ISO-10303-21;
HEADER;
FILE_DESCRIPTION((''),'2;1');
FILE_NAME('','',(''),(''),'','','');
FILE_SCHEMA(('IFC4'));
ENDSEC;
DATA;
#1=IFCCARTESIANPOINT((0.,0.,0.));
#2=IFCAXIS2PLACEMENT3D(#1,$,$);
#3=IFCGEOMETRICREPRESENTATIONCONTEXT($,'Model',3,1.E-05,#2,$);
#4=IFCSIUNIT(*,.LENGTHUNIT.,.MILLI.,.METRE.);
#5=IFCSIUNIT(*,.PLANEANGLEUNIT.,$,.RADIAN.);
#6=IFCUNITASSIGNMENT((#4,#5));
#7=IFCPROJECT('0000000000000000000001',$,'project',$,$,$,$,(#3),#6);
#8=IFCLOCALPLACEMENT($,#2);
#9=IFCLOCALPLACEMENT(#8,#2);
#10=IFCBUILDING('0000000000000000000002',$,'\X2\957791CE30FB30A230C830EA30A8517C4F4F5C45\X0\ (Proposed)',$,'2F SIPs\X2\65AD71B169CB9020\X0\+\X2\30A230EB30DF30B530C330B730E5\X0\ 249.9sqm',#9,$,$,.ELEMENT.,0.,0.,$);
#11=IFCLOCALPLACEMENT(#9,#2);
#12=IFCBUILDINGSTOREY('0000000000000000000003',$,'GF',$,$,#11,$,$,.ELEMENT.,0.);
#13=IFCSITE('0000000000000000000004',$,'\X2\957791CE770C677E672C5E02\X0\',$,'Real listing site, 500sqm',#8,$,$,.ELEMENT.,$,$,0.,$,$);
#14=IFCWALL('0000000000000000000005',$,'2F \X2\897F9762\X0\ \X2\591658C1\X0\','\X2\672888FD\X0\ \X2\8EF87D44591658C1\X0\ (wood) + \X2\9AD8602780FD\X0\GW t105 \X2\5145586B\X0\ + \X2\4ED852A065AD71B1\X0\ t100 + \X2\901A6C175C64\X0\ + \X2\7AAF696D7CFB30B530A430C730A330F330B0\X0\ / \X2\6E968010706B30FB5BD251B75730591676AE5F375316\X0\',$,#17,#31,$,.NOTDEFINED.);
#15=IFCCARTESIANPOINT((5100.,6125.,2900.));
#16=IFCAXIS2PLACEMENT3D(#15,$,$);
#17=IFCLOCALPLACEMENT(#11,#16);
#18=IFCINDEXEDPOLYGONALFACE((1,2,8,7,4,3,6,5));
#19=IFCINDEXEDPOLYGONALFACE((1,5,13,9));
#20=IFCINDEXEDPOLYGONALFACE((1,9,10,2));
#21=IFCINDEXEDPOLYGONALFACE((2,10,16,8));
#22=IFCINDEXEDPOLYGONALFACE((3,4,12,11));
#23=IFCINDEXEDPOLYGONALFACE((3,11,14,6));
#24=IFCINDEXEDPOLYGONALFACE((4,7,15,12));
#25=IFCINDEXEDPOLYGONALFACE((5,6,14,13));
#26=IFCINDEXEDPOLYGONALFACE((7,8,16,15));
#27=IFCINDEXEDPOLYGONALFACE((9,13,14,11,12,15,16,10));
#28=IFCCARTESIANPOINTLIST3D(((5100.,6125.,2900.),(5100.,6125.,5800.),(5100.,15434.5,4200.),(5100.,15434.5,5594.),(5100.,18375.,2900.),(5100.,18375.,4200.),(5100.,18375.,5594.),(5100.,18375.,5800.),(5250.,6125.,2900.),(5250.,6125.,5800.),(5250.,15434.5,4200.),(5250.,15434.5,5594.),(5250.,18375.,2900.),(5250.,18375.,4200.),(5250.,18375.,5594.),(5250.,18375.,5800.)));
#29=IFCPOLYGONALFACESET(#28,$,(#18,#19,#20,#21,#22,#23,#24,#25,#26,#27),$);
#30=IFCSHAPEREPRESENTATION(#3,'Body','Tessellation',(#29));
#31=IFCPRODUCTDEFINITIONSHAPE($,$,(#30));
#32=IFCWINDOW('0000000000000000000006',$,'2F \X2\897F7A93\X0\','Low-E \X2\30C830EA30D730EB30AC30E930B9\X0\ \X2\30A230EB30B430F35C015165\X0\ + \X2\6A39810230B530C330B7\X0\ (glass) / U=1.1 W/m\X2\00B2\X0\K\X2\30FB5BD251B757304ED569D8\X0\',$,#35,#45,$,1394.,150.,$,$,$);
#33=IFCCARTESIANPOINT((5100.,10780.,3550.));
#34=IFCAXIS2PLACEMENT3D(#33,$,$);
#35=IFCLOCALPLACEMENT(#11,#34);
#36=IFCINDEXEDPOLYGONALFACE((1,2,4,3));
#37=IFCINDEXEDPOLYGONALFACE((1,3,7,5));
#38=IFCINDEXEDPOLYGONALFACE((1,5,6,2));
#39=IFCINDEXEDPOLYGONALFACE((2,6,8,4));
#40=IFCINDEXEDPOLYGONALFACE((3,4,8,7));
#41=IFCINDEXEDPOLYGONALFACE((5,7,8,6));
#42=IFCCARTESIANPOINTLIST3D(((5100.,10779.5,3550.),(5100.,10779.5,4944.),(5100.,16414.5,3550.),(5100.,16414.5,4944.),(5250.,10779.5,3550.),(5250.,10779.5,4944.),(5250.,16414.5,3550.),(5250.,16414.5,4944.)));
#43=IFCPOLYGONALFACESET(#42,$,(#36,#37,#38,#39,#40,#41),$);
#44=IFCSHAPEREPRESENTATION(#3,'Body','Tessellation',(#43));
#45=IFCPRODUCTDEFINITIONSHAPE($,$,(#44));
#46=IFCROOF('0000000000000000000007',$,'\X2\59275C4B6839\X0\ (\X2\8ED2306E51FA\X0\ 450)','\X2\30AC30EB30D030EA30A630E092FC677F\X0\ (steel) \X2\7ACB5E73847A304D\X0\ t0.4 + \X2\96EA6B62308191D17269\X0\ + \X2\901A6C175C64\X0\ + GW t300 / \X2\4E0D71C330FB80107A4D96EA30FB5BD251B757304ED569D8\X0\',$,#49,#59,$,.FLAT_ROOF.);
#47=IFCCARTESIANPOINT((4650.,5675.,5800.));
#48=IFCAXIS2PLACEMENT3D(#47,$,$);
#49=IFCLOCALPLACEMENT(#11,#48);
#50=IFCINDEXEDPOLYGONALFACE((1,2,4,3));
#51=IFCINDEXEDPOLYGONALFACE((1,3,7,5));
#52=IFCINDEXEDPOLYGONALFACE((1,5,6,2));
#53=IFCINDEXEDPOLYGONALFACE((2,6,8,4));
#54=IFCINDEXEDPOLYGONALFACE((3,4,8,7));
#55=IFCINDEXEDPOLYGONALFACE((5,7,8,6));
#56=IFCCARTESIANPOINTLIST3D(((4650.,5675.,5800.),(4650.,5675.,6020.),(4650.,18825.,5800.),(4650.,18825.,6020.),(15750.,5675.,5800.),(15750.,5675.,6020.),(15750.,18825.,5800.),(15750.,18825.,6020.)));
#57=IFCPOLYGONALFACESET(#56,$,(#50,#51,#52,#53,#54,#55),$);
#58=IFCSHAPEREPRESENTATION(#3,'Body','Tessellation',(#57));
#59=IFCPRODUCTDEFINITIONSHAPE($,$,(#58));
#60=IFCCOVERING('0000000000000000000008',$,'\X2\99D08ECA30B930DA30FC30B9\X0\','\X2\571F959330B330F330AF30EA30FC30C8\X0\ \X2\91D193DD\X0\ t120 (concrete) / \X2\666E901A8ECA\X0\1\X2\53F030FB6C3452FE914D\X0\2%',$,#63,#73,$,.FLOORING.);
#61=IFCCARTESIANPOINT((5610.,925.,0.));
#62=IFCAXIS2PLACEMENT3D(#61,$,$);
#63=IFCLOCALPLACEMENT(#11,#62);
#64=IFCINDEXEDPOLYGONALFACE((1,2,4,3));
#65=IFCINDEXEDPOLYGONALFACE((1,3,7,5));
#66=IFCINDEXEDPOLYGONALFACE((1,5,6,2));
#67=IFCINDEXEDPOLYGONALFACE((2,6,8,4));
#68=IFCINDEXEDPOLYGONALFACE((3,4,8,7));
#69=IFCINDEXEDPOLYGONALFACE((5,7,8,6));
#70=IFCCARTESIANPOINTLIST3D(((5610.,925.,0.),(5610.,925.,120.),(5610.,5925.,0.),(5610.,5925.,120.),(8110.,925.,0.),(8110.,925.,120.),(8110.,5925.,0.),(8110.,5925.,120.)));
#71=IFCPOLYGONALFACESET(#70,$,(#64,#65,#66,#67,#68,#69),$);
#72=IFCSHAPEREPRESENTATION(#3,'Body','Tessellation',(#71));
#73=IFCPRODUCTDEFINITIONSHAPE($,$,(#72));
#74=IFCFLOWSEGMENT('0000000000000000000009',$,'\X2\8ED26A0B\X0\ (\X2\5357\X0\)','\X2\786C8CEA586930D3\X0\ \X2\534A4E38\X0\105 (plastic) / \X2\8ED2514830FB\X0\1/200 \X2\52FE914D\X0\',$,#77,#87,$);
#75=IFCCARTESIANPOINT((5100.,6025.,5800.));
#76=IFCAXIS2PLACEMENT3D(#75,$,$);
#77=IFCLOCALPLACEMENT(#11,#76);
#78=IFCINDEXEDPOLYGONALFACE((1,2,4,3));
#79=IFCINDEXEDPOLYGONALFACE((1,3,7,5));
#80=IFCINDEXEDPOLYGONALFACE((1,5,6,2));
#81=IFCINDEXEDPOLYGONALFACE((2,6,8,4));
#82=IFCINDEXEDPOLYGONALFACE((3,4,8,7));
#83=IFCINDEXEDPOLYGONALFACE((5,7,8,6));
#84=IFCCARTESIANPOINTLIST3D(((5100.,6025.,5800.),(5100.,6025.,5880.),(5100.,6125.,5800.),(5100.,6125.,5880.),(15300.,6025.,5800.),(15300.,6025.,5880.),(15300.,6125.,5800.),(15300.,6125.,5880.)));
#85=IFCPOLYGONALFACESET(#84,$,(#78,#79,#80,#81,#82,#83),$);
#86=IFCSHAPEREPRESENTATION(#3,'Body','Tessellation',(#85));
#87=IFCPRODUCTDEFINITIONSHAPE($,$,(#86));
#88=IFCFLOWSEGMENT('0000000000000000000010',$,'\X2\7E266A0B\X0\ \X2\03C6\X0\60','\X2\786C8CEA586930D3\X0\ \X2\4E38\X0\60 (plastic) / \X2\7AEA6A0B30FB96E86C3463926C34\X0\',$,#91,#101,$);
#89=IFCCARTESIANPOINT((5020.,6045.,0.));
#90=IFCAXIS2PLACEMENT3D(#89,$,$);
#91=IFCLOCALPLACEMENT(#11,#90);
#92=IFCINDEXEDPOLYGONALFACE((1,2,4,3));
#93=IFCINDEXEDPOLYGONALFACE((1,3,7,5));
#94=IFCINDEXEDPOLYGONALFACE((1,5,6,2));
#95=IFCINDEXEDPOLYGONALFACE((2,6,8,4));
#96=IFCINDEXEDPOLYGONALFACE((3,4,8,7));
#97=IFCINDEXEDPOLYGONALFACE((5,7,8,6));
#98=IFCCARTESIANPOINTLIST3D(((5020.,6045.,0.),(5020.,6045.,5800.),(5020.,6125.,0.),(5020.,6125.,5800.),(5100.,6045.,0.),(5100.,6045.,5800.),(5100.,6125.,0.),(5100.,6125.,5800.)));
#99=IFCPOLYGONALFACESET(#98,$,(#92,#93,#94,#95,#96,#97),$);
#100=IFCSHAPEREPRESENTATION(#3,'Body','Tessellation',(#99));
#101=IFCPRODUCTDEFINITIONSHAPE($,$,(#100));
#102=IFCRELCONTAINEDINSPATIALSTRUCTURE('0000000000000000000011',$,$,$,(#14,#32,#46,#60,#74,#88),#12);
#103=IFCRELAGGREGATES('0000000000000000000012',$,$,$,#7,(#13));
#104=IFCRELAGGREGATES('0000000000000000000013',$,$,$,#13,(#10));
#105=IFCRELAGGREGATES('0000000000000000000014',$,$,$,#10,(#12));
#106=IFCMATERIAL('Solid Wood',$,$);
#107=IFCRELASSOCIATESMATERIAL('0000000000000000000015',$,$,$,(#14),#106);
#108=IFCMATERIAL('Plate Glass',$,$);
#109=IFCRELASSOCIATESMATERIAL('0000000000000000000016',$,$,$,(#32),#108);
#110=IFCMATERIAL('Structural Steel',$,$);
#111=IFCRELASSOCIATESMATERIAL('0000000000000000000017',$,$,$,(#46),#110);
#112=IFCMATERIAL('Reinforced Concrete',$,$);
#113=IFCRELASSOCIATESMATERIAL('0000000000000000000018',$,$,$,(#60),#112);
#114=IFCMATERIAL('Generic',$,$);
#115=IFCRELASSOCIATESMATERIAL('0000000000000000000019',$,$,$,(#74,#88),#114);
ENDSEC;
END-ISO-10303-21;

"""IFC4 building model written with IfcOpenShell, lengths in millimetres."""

from ifc_helpers import new_model, si_unit, frame, frame_2d, origin, place, context, project, spatial, rectangle, extrude, material, element, fill, save


model = new_model("IFC4")

# Units and contexts
model_context = context("Model", 3, precision=1e-05, world=origin())
ifc_project = project(units=[si_unit("LENGTHUNIT", "METRE", prefix="MILLI"), si_unit("PLANEANGLEUNIT", "RADIAN")], contexts=[model_context])

# Site, building, storey
site_placement = place(None, origin())
site = spatial("IfcSite", under=ifc_project, at=site_placement, Name="長野県松本市", ObjectType="Real listing site, 500sqm", CompositionType="ELEMENT", RefElevation=0.0)
building_placement = place(site_placement, origin())
building = spatial("IfcBuilding", under=site, at=building_placement, Name="長野・アトリエ兼住居 (Proposed)", ObjectType="2F SIPs断熱構造+アルミサッシュ 249.9sqm", CompositionType="ELEMENT", ElevationOfRefHeight=0.0, ElevationOfTerrain=0.0)
storey_placement = place(building_placement, origin())
storey = spatial("IfcBuildingStorey", under=building, at=storey_placement, Name="GF", CompositionType="ELEMENT", Elevation=0.0)

# Shared definitions
ifc_material_1 = material(Name="Solid Wood")

# Shared definitions
ifc_material_2 = material(Name="Reinforced Concrete")

# Shared definitions
ifc_material_3 = material(Name="Plate Glass")

# Wall, opening, window
wall_1_placement = place(storey_placement, frame((5100.0, 6125.0, 2900.0)))
wall_1 = element("IfcWall", 1, at=wall_1_placement, inside=storey, material=ifc_material_1, Name="2F 西面 外壁", Description="木製 軸組外壁 (wood) + 高性能GW t105 充填 + 付加断熱 t100 + 通気層 + 窯業系サイディング / 準耐火・寒冷地外皮強化", PredefinedType="NOTDEFINED", context=model_context, shape_type="SweptSolid", body=[
    extrude(rectangle(XDim=150.0, YDim=12250.0, at=frame_2d((75.0, 6125.0))), frame((5100.0, 6125.0, 2900.0)), (0.0, 0.0, 1.0), 2900.0),
])
opening_1_placement = place(storey_placement, frame((5100.0, 10780.0, 3550.0)))
opening_1 = element("IfcOpeningElement", 2, at=opening_1_placement, cuts=wall_1, PredefinedType="NOTDEFINED", context=model_context, shape_type="SweptSolid", body=[
    extrude(rectangle(XDim=150.0, YDim=5635.0, at=frame_2d((75.0, 2817.0))), frame((5100.0, 10780.0, 3550.0)), (0.0, 0.0, 1.0), 1394.0),
])
window_1_placement = place(storey_placement, frame((5100.0, 10780.0, 3550.0)))
window_1 = element("IfcWindow", 3, at=window_1_placement, inside=storey, material=ifc_material_3, Name="2F 西窓", Description="Low-E トリプルガラス アルゴン封入 + 樹脂サッシ (glass) / U=1.1 W/m²K・寒冷地仕様", OverallHeight=1394.0, OverallWidth=150.0, context=model_context, shape_type="SweptSolid", body=[
    extrude(rectangle(XDim=150.0, YDim=5635.0, at=frame_2d((75.0, 2817.0))), frame((5100.0, 10780.0, 3550.0)), (0.0, 0.0, 1.0), 1394.0),
])
fill(opening_1, window_1)

# Roof
ifc_material_4 = material(Name="Structural Steel")
roof_placement = place(storey_placement, frame((4650.0, 5675.0, 5800.0)))
element("IfcRoof", 4, at=roof_placement, inside=storey, material=ifc_material_4, Name="大屋根 (軒の出 450)", Description="ガルバリウム鋼板 (steel) 立平葺き t0.4 + 雪止め金物 + 通気層 + GW t300 / 不燃・耐積雪・寒冷地仕様", PredefinedType="FLAT_ROOF", context=model_context, shape_type="SweptSolid", body=[
    extrude(rectangle(XDim=11100.0, YDim=13150.0, at=frame_2d((5550.0, 6575.0))), frame((4650.0, 5675.0, 5800.0)), (0.0, 0.0, 1.0), 220.0),
])

# Covering
covering_placement = place(storey_placement, frame((5610.0, 925.0, 0.0)))
element("IfcCovering", 5, at=covering_placement, inside=storey, material=ifc_material_2, Name="駐車スペース", Description="土間コンクリート 金鏝 t120 (concrete) / 普通車1台・水勾配2%", PredefinedType="FLOORING", context=model_context, shape_type="SweptSolid", body=[
    extrude(rectangle(XDim=2500.0, YDim=5000.0, at=frame_2d((1250.0, 2500.0))), frame((5610.0, 925.0, 0.0)), (0.0, 0.0, 1.0), 120.0),
])

# Flow segments
ifc_material_5 = material(Name="Generic")
flow_segment_1_placement = place(storey_placement, frame((5100.0, 6025.0, 5800.0)))
element("IfcFlowSegment", 6, at=flow_segment_1_placement, inside=storey, material=ifc_material_5, Name="軒樋 (南)", Description="硬質塩ビ 半丸105 (plastic) / 軒先・1/200 勾配", context=model_context, shape_type="SweptSolid", body=[
    extrude(rectangle(XDim=10200.0, YDim=100.0, at=frame_2d((5100.0, 50.0))), frame((5100.0, 6025.0, 5800.0)), (0.0, 0.0, 1.0), 80.0),
])
flow_segment_2_placement = place(storey_placement, frame((5020.0, 6045.0, 0.0)))
element("IfcFlowSegment", 7, at=flow_segment_2_placement, inside=storey, material=ifc_material_5, Name="縦樋 φ60", Description="硬質塩ビ 丸60 (plastic) / 竪樋・雨水排水", context=model_context, shape_type="SweptSolid", body=[
    extrude(rectangle(XDim=80.0, YDim=80.0, at=frame_2d((40.0, 40.0))), frame((5020.0, 6045.0, 0.0)), (0.0, 0.0, 1.0), 5800.0),
])

save(model, "model.ifc")
